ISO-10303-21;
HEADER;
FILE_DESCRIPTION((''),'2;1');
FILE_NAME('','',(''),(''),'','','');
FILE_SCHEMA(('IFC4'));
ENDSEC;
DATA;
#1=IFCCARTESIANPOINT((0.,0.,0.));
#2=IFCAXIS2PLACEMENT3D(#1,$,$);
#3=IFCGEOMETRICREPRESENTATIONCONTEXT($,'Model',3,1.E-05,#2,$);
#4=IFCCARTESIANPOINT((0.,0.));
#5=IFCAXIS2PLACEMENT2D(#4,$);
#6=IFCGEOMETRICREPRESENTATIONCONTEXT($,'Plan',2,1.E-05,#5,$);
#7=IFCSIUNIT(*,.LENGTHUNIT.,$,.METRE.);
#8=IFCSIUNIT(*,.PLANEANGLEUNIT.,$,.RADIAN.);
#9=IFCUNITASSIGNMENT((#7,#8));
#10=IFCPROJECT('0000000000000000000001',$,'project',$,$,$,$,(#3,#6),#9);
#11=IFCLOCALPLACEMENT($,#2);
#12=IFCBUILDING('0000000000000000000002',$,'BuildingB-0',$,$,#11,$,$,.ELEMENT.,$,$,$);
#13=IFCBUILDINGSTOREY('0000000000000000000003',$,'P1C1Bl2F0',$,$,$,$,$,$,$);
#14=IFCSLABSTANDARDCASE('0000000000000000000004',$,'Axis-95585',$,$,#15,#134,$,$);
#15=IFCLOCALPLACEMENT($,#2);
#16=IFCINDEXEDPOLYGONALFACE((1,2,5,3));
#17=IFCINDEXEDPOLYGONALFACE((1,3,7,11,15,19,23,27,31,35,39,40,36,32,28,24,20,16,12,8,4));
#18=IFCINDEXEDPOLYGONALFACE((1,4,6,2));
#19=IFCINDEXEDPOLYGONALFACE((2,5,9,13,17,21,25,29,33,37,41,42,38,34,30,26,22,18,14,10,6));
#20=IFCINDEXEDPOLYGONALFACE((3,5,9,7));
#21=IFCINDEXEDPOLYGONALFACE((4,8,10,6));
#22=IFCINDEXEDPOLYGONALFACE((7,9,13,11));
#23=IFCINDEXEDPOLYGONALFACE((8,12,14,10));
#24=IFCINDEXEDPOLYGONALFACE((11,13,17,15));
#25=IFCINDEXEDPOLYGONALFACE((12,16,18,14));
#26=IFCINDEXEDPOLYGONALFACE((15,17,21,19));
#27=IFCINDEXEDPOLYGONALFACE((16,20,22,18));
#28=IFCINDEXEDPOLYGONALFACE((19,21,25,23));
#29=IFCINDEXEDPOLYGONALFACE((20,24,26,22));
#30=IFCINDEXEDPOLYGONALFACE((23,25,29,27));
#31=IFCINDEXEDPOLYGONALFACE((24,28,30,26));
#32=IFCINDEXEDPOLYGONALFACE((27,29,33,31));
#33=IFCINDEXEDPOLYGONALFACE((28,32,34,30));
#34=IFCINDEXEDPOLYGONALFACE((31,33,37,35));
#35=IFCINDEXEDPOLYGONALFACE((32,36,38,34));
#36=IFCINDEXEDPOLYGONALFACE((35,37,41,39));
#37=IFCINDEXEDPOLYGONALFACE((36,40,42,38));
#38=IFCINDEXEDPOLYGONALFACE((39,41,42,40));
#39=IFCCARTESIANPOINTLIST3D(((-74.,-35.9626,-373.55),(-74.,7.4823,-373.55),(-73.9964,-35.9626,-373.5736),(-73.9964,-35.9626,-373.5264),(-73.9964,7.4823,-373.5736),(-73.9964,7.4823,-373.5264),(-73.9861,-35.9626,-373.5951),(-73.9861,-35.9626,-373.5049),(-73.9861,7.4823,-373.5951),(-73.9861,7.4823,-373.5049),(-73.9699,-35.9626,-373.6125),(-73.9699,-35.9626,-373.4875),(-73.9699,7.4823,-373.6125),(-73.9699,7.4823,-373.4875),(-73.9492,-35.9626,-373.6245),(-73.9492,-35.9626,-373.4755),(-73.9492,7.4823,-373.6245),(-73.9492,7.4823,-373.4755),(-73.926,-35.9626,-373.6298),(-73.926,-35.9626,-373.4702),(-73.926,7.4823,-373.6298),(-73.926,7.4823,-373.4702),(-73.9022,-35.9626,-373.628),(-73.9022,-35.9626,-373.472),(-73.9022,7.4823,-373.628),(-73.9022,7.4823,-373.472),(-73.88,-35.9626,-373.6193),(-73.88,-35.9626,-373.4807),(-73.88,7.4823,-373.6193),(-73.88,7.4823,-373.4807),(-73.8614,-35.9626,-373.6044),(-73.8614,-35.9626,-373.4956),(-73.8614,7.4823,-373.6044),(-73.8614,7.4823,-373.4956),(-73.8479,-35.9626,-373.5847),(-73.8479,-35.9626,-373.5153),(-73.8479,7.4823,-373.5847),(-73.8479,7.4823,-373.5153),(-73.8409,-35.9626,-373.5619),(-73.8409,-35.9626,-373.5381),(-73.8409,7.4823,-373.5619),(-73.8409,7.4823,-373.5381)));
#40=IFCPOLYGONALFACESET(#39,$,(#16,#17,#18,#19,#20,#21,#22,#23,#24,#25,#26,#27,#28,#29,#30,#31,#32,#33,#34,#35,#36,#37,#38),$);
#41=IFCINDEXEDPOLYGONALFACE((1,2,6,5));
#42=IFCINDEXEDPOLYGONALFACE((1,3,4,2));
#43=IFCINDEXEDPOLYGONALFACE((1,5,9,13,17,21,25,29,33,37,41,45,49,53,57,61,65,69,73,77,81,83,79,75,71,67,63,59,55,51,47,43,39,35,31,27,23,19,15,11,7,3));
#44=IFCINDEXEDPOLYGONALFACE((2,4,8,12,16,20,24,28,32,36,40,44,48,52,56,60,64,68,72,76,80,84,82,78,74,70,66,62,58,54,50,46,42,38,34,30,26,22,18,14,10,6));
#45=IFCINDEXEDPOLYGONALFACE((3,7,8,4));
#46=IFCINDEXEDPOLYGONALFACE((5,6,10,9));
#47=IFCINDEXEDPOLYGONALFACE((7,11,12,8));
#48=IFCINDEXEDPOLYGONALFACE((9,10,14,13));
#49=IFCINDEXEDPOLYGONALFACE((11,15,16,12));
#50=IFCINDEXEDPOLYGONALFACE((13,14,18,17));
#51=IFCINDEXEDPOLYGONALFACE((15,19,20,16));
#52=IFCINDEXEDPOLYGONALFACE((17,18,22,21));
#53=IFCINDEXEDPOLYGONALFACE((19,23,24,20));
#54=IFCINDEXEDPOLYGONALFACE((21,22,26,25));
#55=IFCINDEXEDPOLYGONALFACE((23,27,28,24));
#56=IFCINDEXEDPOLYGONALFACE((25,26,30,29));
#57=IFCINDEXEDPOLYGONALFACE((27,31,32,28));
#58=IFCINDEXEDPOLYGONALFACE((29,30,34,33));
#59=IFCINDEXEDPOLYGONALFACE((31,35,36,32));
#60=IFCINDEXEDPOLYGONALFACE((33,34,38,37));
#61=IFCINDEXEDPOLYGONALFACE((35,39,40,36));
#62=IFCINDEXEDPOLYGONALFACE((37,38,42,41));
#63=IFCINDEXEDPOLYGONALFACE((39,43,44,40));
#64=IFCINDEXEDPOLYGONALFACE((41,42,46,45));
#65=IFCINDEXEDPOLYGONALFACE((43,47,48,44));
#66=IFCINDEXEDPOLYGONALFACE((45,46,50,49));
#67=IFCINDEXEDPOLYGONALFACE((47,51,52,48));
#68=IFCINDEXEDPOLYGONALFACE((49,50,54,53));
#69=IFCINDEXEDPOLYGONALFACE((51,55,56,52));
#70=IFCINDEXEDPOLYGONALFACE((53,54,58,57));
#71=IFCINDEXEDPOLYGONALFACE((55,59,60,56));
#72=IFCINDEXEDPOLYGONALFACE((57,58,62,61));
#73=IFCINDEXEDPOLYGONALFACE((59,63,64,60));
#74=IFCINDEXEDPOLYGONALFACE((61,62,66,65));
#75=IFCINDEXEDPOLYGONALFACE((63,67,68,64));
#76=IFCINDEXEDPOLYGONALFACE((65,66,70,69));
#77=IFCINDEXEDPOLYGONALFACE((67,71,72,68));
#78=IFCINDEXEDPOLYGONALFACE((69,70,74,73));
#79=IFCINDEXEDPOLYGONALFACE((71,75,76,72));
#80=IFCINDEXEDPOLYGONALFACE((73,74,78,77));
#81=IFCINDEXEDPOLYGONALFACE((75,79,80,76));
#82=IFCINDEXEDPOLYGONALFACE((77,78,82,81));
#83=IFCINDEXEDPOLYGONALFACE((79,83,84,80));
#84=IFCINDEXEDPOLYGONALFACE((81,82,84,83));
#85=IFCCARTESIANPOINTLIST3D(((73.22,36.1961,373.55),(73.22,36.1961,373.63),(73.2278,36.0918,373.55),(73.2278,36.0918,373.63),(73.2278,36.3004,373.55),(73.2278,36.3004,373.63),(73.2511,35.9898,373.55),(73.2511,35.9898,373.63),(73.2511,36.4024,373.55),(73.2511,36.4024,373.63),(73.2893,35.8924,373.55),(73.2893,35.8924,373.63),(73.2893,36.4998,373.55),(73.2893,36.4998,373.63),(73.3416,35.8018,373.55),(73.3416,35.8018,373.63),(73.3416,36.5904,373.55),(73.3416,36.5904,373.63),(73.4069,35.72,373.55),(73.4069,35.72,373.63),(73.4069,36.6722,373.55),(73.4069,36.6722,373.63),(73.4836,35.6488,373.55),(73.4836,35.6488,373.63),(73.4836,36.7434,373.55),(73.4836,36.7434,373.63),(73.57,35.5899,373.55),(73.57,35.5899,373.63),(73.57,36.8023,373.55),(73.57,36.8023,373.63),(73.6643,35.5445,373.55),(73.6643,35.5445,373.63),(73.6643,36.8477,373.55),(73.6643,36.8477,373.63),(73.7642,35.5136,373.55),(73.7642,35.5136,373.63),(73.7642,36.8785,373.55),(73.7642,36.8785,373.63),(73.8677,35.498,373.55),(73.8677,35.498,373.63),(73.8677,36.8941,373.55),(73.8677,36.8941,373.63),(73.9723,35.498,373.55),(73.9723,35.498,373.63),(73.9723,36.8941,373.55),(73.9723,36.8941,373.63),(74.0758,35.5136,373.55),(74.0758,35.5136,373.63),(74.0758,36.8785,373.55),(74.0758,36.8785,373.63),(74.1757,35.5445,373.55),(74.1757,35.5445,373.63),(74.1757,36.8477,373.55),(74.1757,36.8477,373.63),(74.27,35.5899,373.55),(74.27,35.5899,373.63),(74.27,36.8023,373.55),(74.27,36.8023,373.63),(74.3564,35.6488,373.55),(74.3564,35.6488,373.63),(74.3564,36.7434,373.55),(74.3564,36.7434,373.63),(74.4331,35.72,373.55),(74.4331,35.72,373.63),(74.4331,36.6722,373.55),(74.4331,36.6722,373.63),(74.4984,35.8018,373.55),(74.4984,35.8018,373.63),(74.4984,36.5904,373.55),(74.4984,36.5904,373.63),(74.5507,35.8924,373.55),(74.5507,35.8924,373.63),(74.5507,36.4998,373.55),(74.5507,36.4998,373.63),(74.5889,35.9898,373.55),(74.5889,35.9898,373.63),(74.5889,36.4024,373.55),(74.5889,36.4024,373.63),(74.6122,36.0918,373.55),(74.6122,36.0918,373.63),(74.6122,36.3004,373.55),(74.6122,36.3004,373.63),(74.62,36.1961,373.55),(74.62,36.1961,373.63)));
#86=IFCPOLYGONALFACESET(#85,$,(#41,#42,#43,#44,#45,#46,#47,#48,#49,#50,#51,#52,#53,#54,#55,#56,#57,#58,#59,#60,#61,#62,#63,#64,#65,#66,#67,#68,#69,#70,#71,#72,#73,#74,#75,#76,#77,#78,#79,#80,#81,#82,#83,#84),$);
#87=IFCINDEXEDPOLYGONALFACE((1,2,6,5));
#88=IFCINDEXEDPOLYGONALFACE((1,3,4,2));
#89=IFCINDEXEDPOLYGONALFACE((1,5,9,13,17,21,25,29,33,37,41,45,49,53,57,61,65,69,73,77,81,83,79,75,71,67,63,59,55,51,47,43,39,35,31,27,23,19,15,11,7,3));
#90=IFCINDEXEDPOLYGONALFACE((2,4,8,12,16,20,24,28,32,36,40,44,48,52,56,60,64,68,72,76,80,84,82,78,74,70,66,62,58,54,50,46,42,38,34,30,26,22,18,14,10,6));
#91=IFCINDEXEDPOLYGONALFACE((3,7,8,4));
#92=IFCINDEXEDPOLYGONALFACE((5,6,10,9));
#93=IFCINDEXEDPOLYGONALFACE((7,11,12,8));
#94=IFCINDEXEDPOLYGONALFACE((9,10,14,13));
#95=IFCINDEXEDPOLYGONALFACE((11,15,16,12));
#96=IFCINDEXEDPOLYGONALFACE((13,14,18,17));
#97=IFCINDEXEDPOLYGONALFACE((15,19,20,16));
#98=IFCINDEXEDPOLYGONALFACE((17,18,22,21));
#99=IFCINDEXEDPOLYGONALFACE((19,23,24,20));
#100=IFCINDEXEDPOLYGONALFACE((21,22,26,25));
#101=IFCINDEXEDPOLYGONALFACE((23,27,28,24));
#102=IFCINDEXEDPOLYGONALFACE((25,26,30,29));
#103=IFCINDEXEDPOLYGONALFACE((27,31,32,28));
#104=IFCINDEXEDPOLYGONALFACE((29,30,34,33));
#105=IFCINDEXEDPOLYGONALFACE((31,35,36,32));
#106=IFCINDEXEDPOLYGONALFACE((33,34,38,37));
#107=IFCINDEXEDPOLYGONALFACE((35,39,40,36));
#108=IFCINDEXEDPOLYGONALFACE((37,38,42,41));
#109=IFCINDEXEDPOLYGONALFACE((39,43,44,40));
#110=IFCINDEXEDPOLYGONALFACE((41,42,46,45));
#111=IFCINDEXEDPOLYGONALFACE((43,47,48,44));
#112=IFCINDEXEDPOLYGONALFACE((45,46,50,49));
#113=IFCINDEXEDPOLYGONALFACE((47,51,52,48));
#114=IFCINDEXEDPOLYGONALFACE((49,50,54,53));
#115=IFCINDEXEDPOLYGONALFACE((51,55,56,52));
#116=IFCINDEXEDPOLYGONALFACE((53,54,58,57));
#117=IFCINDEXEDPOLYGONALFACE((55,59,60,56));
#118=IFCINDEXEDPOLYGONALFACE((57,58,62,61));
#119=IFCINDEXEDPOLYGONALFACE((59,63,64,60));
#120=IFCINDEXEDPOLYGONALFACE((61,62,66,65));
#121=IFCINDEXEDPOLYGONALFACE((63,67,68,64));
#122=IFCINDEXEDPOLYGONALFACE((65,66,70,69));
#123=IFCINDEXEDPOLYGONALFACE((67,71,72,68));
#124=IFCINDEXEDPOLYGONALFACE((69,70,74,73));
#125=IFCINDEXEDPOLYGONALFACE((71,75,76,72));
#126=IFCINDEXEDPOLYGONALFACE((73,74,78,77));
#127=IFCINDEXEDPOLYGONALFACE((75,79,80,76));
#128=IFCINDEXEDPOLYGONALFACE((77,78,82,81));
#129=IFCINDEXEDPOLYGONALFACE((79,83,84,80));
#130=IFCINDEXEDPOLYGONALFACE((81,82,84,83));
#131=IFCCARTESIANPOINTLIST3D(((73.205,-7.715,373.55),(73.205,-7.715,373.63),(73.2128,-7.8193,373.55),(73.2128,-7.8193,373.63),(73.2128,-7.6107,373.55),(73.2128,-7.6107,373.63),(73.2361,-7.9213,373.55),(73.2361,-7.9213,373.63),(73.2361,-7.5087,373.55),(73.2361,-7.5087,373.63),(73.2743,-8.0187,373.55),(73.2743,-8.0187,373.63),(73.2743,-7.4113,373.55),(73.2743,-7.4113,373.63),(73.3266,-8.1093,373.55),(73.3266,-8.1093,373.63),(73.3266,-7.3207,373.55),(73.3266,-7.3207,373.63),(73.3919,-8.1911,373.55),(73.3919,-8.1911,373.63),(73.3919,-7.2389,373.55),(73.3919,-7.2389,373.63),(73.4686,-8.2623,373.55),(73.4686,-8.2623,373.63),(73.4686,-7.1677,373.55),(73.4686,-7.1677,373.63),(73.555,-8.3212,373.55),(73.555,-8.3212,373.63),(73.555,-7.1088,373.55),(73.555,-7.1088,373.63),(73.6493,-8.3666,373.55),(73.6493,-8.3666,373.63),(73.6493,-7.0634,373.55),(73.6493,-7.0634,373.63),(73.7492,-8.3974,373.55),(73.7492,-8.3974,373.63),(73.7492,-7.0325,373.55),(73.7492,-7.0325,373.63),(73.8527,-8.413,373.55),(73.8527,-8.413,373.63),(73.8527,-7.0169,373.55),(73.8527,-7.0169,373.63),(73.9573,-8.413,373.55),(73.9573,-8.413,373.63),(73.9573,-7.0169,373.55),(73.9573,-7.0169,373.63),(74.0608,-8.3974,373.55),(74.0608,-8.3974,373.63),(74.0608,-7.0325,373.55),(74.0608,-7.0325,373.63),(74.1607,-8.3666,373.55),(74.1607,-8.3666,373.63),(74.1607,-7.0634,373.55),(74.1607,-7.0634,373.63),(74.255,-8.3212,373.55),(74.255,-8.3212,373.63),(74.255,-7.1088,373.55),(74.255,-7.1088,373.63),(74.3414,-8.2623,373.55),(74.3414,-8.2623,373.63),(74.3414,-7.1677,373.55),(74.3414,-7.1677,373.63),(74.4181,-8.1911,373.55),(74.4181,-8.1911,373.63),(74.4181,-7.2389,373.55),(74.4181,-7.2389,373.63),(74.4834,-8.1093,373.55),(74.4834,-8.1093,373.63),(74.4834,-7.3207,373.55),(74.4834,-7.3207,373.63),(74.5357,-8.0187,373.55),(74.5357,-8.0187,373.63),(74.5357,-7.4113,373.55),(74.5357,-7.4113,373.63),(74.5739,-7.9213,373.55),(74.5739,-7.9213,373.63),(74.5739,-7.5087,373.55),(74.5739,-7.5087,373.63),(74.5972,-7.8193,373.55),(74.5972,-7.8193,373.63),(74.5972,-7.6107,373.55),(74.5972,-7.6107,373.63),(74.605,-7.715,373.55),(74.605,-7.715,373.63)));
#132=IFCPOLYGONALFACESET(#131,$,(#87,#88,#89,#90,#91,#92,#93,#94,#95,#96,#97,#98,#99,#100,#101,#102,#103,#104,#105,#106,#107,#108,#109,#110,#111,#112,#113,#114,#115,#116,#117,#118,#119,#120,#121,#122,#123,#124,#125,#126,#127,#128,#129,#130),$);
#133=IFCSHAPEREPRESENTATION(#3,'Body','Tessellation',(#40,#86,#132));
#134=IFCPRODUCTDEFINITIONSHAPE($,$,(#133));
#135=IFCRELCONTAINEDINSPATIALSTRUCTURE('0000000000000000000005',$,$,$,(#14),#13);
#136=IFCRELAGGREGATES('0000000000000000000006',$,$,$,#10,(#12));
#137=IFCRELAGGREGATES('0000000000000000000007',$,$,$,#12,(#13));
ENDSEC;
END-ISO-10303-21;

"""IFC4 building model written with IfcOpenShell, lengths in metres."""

from ifc_helpers import new_model, entity, si_unit, frame, origin, origin_2d, place, context, project, spatial, circle, extrude, element, save


model = new_model("IFC4")

# Units and contexts
model_context = context("Model", 3, precision=1e-05, world=origin())
plan_context = context("Plan", 2, precision=1e-05, world=origin_2d())
ifc_project = project(units=[si_unit("LENGTHUNIT", "METRE"), si_unit("PLANEANGLEUNIT", "RADIAN")], contexts=[model_context, plan_context])

# Building, storey
building_placement = place(None, origin())
building = spatial("IfcBuilding", under=ifc_project, at=building_placement, Name="BuildingB-0", CompositionType="ELEMENT")
storey = spatial("IfcBuildingStorey", under=building, Name="P1C1Bl2F0")

# Slab
element("IfcSlabStandardCase", 1, inside=storey, Name="Axis-95585", context=model_context, shape_type="AdvancedSweptSolid", body=[
    entity("IfcSurfaceCurveSweptAreaSolid", entity("IfcCircleProfileDef", "AREA", None, None, 0.08), None, entity("IfcPolyline", [entity("IfcCartesianPoint", [73.92, 35.9626, 373.55]), entity("IfcCartesianPoint", [73.92, -7.4823, 373.55])]), None, None, entity("IfcPlane", entity("IfcAxis2Placement3D", entity("IfcCartesianPoint", [73.92, 35.9626, 373.55]), entity("IfcDirection", [0.0, 0.0, 1.0]), entity("IfcDirection", [1.0, 0.0, 0.0])))),
    extrude(circle(Radius=0.7), frame((73.92, 36.1961, 373.55)), (0.0, 0.0, 1.0), 0.08),
    extrude(circle(Radius=0.7), frame((73.905, -7.715, 373.55)), (0.0, 0.0, 1.0), 0.08),
])

save(model, "model.ifc")
